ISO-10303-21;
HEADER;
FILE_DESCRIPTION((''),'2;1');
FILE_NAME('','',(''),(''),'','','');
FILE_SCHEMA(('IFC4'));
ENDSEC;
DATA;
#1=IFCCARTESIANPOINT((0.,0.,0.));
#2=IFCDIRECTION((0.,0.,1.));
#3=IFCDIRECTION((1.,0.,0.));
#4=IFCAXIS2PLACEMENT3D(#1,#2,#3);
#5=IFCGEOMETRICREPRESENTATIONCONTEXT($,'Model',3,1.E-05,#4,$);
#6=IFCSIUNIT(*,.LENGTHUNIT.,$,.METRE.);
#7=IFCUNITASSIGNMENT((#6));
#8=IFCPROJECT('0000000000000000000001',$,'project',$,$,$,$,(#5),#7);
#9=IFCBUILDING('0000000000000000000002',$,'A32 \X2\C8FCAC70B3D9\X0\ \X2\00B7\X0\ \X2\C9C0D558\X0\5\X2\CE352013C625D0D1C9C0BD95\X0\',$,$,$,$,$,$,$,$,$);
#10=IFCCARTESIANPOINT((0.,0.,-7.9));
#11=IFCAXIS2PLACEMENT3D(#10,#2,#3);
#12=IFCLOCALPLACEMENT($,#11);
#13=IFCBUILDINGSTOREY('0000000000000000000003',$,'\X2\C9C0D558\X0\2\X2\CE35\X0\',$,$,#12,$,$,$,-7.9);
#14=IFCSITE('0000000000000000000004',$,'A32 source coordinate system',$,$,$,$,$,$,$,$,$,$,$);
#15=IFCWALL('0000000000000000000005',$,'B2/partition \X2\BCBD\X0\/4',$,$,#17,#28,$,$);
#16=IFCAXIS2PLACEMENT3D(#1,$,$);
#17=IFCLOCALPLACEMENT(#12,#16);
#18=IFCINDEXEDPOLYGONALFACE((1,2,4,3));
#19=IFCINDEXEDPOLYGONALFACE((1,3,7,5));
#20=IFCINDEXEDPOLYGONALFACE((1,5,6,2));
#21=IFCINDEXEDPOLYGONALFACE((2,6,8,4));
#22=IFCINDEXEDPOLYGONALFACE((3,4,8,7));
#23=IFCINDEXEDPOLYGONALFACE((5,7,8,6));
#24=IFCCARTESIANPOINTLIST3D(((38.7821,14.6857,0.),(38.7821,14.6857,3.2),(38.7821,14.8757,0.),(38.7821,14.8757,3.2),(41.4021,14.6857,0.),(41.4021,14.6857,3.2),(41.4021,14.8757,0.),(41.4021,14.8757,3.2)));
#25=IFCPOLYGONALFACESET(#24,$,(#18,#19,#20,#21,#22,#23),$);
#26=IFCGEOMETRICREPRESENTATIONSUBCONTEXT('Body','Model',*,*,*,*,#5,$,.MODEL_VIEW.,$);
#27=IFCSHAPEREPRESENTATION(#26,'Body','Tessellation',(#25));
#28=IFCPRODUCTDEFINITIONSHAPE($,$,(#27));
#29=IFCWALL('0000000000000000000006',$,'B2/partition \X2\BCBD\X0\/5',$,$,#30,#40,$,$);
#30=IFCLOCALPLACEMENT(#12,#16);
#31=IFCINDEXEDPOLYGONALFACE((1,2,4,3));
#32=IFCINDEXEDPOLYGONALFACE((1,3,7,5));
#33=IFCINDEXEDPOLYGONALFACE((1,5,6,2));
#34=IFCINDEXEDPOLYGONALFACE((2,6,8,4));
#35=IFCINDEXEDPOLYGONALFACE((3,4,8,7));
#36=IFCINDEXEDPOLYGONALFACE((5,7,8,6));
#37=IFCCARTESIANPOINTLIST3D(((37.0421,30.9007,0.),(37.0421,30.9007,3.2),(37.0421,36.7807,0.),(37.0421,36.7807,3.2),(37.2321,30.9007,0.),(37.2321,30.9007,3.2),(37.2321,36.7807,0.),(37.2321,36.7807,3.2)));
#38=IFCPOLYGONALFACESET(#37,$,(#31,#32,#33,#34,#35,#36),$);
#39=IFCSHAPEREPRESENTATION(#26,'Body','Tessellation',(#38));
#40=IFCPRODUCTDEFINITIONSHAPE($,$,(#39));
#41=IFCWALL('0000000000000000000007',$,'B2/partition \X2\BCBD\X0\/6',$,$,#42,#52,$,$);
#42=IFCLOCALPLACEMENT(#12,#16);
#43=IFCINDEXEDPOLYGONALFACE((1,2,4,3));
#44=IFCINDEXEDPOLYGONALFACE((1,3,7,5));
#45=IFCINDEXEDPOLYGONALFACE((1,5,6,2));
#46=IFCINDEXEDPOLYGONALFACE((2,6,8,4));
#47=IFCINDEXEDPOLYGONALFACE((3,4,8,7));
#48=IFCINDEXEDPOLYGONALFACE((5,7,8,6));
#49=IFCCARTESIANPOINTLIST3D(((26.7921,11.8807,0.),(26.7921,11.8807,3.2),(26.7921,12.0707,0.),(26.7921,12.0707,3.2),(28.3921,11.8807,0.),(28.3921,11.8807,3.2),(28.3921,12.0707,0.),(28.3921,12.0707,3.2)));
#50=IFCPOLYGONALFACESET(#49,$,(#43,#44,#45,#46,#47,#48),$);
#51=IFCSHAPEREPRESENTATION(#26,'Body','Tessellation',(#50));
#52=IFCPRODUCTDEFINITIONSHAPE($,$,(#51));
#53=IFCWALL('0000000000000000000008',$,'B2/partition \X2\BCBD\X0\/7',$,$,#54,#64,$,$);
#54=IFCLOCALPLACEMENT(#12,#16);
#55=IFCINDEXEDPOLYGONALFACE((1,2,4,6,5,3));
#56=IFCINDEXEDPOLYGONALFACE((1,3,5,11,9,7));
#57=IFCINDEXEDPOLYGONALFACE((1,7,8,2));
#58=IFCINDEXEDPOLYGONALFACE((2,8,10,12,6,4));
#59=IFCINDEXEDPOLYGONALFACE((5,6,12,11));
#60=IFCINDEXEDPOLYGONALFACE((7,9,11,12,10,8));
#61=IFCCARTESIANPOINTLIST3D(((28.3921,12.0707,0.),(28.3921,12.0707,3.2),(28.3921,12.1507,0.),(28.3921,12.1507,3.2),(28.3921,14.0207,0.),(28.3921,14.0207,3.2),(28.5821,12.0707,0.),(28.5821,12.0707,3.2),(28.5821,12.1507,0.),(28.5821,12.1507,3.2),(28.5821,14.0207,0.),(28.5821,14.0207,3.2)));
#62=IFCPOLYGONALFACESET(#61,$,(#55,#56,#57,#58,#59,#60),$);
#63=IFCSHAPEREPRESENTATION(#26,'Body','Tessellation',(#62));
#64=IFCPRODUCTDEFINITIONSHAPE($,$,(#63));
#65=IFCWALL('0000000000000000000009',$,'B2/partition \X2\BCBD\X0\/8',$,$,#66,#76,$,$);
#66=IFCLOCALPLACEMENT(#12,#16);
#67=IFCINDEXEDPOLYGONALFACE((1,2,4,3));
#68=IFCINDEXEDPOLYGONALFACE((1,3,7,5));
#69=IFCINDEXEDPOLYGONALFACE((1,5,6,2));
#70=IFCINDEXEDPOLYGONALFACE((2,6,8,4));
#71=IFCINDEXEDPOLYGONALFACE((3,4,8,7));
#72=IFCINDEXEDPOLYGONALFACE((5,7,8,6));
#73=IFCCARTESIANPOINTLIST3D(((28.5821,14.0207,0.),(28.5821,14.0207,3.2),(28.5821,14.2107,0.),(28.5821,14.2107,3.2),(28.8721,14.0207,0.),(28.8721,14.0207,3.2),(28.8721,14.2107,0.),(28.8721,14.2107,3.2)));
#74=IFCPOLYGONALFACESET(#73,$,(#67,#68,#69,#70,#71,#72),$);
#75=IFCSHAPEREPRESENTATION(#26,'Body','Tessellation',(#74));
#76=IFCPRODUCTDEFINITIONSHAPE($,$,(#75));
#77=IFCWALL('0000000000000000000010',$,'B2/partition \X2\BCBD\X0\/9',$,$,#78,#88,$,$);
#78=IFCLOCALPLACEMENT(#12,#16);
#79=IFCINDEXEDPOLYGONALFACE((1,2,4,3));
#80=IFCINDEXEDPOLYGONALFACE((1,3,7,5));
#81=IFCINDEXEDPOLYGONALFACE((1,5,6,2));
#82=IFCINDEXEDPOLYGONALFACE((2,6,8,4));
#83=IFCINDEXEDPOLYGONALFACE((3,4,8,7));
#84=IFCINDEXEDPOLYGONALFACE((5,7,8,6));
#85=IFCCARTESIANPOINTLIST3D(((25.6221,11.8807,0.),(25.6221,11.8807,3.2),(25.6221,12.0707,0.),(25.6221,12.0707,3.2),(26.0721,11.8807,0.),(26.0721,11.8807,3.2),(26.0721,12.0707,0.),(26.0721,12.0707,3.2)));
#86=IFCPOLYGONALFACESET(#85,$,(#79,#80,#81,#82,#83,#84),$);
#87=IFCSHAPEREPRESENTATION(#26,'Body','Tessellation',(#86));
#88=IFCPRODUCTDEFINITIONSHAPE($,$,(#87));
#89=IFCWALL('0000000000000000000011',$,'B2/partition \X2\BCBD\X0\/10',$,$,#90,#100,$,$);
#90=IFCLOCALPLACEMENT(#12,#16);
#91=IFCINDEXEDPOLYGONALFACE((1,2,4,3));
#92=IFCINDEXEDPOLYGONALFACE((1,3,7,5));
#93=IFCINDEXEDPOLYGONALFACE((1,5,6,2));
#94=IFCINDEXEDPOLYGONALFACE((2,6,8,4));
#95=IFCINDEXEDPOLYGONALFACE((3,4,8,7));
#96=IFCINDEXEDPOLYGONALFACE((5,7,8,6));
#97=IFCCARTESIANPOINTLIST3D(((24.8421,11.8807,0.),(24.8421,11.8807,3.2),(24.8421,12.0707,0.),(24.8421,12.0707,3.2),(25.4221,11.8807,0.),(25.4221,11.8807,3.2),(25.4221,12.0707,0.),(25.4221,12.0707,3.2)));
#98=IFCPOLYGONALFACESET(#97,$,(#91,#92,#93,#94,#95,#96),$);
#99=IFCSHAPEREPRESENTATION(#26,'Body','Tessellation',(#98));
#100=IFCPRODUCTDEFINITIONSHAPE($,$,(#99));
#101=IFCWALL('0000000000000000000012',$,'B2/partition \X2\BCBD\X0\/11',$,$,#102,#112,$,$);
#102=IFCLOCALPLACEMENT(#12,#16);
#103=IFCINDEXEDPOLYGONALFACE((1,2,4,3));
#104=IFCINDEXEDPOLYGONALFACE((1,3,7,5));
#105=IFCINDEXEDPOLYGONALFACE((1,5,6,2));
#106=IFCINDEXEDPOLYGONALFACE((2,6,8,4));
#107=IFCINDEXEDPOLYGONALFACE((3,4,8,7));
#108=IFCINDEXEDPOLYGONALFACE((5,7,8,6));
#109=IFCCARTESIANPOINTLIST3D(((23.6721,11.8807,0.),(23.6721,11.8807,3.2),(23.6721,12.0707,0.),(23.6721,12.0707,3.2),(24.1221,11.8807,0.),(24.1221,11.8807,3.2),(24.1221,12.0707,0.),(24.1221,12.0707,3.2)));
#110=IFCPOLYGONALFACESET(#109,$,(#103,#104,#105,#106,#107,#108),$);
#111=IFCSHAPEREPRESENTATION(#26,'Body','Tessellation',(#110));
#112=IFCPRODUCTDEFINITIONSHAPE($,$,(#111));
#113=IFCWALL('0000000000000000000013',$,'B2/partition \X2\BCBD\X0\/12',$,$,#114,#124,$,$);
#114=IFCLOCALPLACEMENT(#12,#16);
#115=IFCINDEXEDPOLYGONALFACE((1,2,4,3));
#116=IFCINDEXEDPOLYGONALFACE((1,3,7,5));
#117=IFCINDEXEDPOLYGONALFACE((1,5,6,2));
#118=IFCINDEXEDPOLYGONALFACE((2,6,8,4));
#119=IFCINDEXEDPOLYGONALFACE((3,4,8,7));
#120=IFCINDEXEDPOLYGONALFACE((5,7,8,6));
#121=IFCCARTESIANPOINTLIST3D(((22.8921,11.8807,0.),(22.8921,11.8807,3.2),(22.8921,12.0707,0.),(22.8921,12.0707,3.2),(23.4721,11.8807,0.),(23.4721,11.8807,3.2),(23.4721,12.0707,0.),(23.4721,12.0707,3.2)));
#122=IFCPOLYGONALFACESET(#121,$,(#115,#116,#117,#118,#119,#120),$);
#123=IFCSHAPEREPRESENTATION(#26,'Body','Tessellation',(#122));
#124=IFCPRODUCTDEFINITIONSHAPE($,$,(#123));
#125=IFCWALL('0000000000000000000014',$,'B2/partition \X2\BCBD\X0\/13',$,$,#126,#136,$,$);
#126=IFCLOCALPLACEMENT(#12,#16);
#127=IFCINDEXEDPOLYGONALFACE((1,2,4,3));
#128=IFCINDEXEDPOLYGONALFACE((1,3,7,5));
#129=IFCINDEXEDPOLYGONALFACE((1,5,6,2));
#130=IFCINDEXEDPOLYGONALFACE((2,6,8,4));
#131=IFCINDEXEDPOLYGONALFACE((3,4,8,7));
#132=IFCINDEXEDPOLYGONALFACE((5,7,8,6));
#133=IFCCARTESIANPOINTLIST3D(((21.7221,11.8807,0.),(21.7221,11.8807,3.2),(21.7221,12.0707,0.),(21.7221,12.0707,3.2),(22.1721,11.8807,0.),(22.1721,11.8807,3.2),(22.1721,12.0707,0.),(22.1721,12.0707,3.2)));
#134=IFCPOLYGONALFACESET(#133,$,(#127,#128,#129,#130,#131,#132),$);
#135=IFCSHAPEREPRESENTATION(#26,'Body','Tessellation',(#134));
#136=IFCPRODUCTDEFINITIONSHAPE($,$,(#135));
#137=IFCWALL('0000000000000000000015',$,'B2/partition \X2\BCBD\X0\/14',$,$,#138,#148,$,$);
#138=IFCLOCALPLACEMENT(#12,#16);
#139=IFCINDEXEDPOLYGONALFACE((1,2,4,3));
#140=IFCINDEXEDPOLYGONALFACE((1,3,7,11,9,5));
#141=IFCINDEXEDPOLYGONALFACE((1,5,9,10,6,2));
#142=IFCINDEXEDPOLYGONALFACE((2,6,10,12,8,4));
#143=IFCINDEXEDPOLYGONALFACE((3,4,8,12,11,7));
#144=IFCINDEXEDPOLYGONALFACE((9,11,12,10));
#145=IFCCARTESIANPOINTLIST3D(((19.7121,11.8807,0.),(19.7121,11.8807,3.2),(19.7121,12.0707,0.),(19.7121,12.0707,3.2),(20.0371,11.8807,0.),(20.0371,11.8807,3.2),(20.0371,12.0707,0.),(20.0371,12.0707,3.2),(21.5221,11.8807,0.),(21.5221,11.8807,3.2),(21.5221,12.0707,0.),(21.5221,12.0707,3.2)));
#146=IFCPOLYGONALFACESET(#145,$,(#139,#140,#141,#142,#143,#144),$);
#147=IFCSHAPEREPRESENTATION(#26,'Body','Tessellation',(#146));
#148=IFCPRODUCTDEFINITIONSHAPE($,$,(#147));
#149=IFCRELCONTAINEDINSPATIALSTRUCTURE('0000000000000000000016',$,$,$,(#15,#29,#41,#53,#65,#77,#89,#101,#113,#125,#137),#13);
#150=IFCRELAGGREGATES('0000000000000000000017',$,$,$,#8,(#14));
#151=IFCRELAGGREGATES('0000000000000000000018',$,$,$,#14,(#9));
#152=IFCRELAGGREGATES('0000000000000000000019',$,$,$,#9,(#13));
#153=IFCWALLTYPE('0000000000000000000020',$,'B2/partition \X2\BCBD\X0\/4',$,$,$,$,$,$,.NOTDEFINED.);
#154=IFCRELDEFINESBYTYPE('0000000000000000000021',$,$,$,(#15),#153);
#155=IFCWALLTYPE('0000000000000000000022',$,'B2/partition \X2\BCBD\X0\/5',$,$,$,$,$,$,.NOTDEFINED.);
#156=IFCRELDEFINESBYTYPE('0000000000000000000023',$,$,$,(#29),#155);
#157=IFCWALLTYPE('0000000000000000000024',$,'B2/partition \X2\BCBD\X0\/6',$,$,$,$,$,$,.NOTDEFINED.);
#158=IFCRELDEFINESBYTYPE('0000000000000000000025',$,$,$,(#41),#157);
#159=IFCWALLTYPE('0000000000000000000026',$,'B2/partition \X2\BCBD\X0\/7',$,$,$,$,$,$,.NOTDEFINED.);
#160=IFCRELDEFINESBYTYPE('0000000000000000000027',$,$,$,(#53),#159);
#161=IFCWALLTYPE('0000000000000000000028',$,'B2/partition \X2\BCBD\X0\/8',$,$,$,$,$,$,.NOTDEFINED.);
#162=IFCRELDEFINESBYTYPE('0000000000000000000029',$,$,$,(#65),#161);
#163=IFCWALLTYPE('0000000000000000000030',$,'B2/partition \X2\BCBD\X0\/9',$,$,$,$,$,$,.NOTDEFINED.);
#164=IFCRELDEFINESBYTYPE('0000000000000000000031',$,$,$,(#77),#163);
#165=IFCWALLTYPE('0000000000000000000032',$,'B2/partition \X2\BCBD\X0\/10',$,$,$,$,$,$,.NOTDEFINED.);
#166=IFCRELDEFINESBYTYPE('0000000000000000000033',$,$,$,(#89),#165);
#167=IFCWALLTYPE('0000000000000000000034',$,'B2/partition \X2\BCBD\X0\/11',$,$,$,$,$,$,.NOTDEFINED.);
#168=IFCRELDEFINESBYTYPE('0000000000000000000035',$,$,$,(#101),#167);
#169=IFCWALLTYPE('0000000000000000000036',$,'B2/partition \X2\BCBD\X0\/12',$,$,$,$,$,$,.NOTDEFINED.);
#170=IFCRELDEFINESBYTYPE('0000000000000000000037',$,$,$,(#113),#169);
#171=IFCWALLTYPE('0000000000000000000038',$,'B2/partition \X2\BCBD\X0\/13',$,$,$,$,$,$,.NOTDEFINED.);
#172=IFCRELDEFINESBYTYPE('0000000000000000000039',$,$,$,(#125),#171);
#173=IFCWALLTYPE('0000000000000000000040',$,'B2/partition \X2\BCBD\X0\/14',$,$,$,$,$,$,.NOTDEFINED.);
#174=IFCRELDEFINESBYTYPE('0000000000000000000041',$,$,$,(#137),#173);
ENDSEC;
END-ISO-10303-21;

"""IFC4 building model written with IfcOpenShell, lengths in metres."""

from ifc_helpers import new_model, si_unit, frame, origin, origin_with_axes, place, context, subcontext, project, spatial, polyline, outline, extrude, source, transform, mapped, type_object, type_shapes, element, save


model = new_model("IFC4")

# Units and contexts
model_context = context("Model", 3, precision=1e-05, world=origin_with_axes())
body_context = subcontext(model_context, "Body", "Model", "MODEL_VIEW")
ifc_project = project(units=[si_unit("LENGTHUNIT", "METRE")], contexts=[model_context])

# Site, building, storey
site = spatial("IfcSite", under=ifc_project, Name="A32 source coordinate system")
building = spatial("IfcBuilding", under=site, Name="A32 주거동 · 지하5층–옥탑지붕")
storey_placement = place(None, frame((0.0, 0.0, -7.9), z_axis=(0.0, 0.0, 1.0), x_axis=(1.0, 0.0, 0.0)))
storey = spatial("IfcBuildingStorey", under=building, at=storey_placement, Name="지하2층", Elevation=-7.9)

# Walls
wall_type_1 = type_object("IfcWallType", Name="B2/partition 벽/4", PredefinedType="NOTDEFINED")
shared_shape_1 = source(origin(), body_context, "Body", "SweptSolid", [
    extrude(outline(polyline([(38.7821, 14.8757), (41.4021, 14.8757), (41.4021, 14.6857), (38.7821, 14.6857), (38.7821, 14.8757)])), origin(), (0.0, 0.0, 1.0), 3.2),
])
type_shapes(wall_type_1, [shared_shape_1])
wall_1_placement = place(storey_placement, origin_with_axes())
element("IfcWall", 1, at=wall_1_placement, inside=storey, type_object=wall_type_1, Name="B2/partition 벽/4", context=body_context, shape_type="MappedRepresentation", body=[
    mapped(shared_shape_1, transform((0.0, 0.0, 0.0), scale=1.0)),
])
wall_type_2 = type_object("IfcWallType", Name="B2/partition 벽/5", PredefinedType="NOTDEFINED")
shared_shape_2 = source(origin(), body_context, "Body", "SweptSolid", [
    extrude(outline(polyline([(37.2321, 36.7807), (37.2321, 30.9007), (37.0421, 30.9007), (37.0421, 36.7807), (37.2321, 36.7807)])), origin(), (0.0, 0.0, 1.0), 3.2),
])
type_shapes(wall_type_2, [shared_shape_2])
wall_2_placement = place(storey_placement, origin_with_axes())
element("IfcWall", 2, at=wall_2_placement, inside=storey, type_object=wall_type_2, Name="B2/partition 벽/5", context=body_context, shape_type="MappedRepresentation", body=[
    mapped(shared_shape_2, transform((0.0, 0.0, 0.0), scale=1.0)),
])
wall_type_3 = type_object("IfcWallType", Name="B2/partition 벽/6", PredefinedType="NOTDEFINED")
shared_shape_3 = source(origin(), body_context, "Body", "SweptSolid", [
    extrude(outline(polyline([(26.7921, 11.8807), (26.7921, 12.0707), (28.3921, 12.0707), (28.3921, 11.8807), (26.7921, 11.8807)])), origin(), (0.0, 0.0, 1.0), 3.2),
])
type_shapes(wall_type_3, [shared_shape_3])
wall_3_placement = place(storey_placement, origin_with_axes())
element("IfcWall", 3, at=wall_3_placement, inside=storey, type_object=wall_type_3, Name="B2/partition 벽/6", context=body_context, shape_type="MappedRepresentation", body=[
    mapped(shared_shape_3, transform((0.0, 0.0, 0.0), scale=1.0)),
])
wall_type_4 = type_object("IfcWallType", Name="B2/partition 벽/7", PredefinedType="NOTDEFINED")
shared_shape_4 = source(origin(), body_context, "Body", "SweptSolid", [
    extrude(outline(polyline([(28.3921, 12.1507), (28.3921, 14.0207), (28.5821, 14.0207), (28.5821, 12.1507), (28.5821, 12.0707), (28.3921, 12.0707), (28.3921, 12.1507)])), origin(), (0.0, 0.0, 1.0), 3.2),
])
type_shapes(wall_type_4, [shared_shape_4])
wall_4_placement = place(storey_placement, origin_with_axes())
element("IfcWall", 4, at=wall_4_placement, inside=storey, type_object=wall_type_4, Name="B2/partition 벽/7", context=body_context, shape_type="MappedRepresentation", body=[
    mapped(shared_shape_4, transform((0.0, 0.0, 0.0), scale=1.0)),
])
wall_type_5 = type_object("IfcWallType", Name="B2/partition 벽/8", PredefinedType="NOTDEFINED")
shared_shape_5 = source(origin(), body_context, "Body", "SweptSolid", [
    extrude(outline(polyline([(28.5821, 14.2107), (28.8721, 14.2107), (28.8721, 14.0207), (28.5821, 14.0207), (28.5821, 14.2107)])), origin(), (0.0, 0.0, 1.0), 3.2),
])
type_shapes(wall_type_5, [shared_shape_5])
wall_5_placement = place(storey_placement, origin_with_axes())
element("IfcWall", 5, at=wall_5_placement, inside=storey, type_object=wall_type_5, Name="B2/partition 벽/8", context=body_context, shape_type="MappedRepresentation", body=[
    mapped(shared_shape_5, transform((0.0, 0.0, 0.0), scale=1.0)),
])
wall_type_6 = type_object("IfcWallType", Name="B2/partition 벽/9", PredefinedType="NOTDEFINED")
shared_shape_6 = source(origin(), body_context, "Body", "SweptSolid", [
    extrude(outline(polyline([(26.0721, 12.0707), (26.0721, 11.8807), (25.6221, 11.8807), (25.6221, 12.0707), (26.0721, 12.0707)])), origin(), (0.0, 0.0, 1.0), 3.2),
])
type_shapes(wall_type_6, [shared_shape_6])
wall_6_placement = place(storey_placement, origin_with_axes())
element("IfcWall", 6, at=wall_6_placement, inside=storey, type_object=wall_type_6, Name="B2/partition 벽/9", context=body_context, shape_type="MappedRepresentation", body=[
    mapped(shared_shape_6, transform((0.0, 0.0, 0.0), scale=1.0)),
])
wall_type_7 = type_object("IfcWallType", Name="B2/partition 벽/10", PredefinedType="NOTDEFINED")
shared_shape_7 = source(origin(), body_context, "Body", "SweptSolid", [
    extrude(outline(polyline([(25.4221, 12.0707), (25.4221, 11.8807), (24.8421, 11.8807), (24.8421, 12.0707), (25.4221, 12.0707)])), origin(), (0.0, 0.0, 1.0), 3.2),
])
type_shapes(wall_type_7, [shared_shape_7])
wall_7_placement = place(storey_placement, origin_with_axes())
element("IfcWall", 7, at=wall_7_placement, inside=storey, type_object=wall_type_7, Name="B2/partition 벽/10", context=body_context, shape_type="MappedRepresentation", body=[
    mapped(shared_shape_7, transform((0.0, 0.0, 0.0), scale=1.0)),
])
wall_type_8 = type_object("IfcWallType", Name="B2/partition 벽/11", PredefinedType="NOTDEFINED")
shared_shape_8 = source(origin(), body_context, "Body", "SweptSolid", [
    extrude(outline(polyline([(23.6721, 12.0707), (24.1221, 12.0707), (24.1221, 11.8807), (23.6721, 11.8807), (23.6721, 12.0707)])), origin(), (0.0, 0.0, 1.0), 3.2),
])
type_shapes(wall_type_8, [shared_shape_8])
wall_8_placement = place(storey_placement, origin_with_axes())
element("IfcWall", 8, at=wall_8_placement, inside=storey, type_object=wall_type_8, Name="B2/partition 벽/11", context=body_context, shape_type="MappedRepresentation", body=[
    mapped(shared_shape_8, transform((0.0, 0.0, 0.0), scale=1.0)),
])
wall_type_9 = type_object("IfcWallType", Name="B2/partition 벽/12", PredefinedType="NOTDEFINED")
shared_shape_9 = source(origin(), body_context, "Body", "SweptSolid", [
    extrude(outline(polyline([(23.4721, 12.0707), (23.4721, 11.8807), (22.8921, 11.8807), (22.8921, 12.0707), (23.4721, 12.0707)])), origin(), (0.0, 0.0, 1.0), 3.2),
])
type_shapes(wall_type_9, [shared_shape_9])
wall_9_placement = place(storey_placement, origin_with_axes())
element("IfcWall", 9, at=wall_9_placement, inside=storey, type_object=wall_type_9, Name="B2/partition 벽/12", context=body_context, shape_type="MappedRepresentation", body=[
    mapped(shared_shape_9, transform((0.0, 0.0, 0.0), scale=1.0)),
])
wall_type_10 = type_object("IfcWallType", Name="B2/partition 벽/13", PredefinedType="NOTDEFINED")
shared_shape_10 = source(origin(), body_context, "Body", "SweptSolid", [
    extrude(outline(polyline([(22.1721, 12.0707), (22.1721, 11.8807), (21.7221, 11.8807), (21.7221, 12.0707), (22.1721, 12.0707)])), origin(), (0.0, 0.0, 1.0), 3.2),
])
type_shapes(wall_type_10, [shared_shape_10])
wall_10_placement = place(storey_placement, origin_with_axes())
element("IfcWall", 10, at=wall_10_placement, inside=storey, type_object=wall_type_10, Name="B2/partition 벽/13", context=body_context, shape_type="MappedRepresentation", body=[
    mapped(shared_shape_10, transform((0.0, 0.0, 0.0), scale=1.0)),
])
wall_type_11 = type_object("IfcWallType", Name="B2/partition 벽/14", PredefinedType="NOTDEFINED")
shared_shape_11 = source(origin(), body_context, "Body", "SweptSolid", [
    extrude(outline(polyline([(19.7121, 11.8807), (19.7121, 12.0707), (20.0371, 12.0707), (21.5221, 12.0707), (21.5221, 11.8807), (20.0371, 11.8807), (19.7121, 11.8807)])), origin(), (0.0, 0.0, 1.0), 3.2),
])
type_shapes(wall_type_11, [shared_shape_11])
wall_11_placement = place(storey_placement, origin_with_axes())
element("IfcWall", 11, at=wall_11_placement, inside=storey, type_object=wall_type_11, Name="B2/partition 벽/14", context=body_context, shape_type="MappedRepresentation", body=[
    mapped(shared_shape_11, transform((0.0, 0.0, 0.0), scale=1.0)),
])

save(model, "model.ifc")
